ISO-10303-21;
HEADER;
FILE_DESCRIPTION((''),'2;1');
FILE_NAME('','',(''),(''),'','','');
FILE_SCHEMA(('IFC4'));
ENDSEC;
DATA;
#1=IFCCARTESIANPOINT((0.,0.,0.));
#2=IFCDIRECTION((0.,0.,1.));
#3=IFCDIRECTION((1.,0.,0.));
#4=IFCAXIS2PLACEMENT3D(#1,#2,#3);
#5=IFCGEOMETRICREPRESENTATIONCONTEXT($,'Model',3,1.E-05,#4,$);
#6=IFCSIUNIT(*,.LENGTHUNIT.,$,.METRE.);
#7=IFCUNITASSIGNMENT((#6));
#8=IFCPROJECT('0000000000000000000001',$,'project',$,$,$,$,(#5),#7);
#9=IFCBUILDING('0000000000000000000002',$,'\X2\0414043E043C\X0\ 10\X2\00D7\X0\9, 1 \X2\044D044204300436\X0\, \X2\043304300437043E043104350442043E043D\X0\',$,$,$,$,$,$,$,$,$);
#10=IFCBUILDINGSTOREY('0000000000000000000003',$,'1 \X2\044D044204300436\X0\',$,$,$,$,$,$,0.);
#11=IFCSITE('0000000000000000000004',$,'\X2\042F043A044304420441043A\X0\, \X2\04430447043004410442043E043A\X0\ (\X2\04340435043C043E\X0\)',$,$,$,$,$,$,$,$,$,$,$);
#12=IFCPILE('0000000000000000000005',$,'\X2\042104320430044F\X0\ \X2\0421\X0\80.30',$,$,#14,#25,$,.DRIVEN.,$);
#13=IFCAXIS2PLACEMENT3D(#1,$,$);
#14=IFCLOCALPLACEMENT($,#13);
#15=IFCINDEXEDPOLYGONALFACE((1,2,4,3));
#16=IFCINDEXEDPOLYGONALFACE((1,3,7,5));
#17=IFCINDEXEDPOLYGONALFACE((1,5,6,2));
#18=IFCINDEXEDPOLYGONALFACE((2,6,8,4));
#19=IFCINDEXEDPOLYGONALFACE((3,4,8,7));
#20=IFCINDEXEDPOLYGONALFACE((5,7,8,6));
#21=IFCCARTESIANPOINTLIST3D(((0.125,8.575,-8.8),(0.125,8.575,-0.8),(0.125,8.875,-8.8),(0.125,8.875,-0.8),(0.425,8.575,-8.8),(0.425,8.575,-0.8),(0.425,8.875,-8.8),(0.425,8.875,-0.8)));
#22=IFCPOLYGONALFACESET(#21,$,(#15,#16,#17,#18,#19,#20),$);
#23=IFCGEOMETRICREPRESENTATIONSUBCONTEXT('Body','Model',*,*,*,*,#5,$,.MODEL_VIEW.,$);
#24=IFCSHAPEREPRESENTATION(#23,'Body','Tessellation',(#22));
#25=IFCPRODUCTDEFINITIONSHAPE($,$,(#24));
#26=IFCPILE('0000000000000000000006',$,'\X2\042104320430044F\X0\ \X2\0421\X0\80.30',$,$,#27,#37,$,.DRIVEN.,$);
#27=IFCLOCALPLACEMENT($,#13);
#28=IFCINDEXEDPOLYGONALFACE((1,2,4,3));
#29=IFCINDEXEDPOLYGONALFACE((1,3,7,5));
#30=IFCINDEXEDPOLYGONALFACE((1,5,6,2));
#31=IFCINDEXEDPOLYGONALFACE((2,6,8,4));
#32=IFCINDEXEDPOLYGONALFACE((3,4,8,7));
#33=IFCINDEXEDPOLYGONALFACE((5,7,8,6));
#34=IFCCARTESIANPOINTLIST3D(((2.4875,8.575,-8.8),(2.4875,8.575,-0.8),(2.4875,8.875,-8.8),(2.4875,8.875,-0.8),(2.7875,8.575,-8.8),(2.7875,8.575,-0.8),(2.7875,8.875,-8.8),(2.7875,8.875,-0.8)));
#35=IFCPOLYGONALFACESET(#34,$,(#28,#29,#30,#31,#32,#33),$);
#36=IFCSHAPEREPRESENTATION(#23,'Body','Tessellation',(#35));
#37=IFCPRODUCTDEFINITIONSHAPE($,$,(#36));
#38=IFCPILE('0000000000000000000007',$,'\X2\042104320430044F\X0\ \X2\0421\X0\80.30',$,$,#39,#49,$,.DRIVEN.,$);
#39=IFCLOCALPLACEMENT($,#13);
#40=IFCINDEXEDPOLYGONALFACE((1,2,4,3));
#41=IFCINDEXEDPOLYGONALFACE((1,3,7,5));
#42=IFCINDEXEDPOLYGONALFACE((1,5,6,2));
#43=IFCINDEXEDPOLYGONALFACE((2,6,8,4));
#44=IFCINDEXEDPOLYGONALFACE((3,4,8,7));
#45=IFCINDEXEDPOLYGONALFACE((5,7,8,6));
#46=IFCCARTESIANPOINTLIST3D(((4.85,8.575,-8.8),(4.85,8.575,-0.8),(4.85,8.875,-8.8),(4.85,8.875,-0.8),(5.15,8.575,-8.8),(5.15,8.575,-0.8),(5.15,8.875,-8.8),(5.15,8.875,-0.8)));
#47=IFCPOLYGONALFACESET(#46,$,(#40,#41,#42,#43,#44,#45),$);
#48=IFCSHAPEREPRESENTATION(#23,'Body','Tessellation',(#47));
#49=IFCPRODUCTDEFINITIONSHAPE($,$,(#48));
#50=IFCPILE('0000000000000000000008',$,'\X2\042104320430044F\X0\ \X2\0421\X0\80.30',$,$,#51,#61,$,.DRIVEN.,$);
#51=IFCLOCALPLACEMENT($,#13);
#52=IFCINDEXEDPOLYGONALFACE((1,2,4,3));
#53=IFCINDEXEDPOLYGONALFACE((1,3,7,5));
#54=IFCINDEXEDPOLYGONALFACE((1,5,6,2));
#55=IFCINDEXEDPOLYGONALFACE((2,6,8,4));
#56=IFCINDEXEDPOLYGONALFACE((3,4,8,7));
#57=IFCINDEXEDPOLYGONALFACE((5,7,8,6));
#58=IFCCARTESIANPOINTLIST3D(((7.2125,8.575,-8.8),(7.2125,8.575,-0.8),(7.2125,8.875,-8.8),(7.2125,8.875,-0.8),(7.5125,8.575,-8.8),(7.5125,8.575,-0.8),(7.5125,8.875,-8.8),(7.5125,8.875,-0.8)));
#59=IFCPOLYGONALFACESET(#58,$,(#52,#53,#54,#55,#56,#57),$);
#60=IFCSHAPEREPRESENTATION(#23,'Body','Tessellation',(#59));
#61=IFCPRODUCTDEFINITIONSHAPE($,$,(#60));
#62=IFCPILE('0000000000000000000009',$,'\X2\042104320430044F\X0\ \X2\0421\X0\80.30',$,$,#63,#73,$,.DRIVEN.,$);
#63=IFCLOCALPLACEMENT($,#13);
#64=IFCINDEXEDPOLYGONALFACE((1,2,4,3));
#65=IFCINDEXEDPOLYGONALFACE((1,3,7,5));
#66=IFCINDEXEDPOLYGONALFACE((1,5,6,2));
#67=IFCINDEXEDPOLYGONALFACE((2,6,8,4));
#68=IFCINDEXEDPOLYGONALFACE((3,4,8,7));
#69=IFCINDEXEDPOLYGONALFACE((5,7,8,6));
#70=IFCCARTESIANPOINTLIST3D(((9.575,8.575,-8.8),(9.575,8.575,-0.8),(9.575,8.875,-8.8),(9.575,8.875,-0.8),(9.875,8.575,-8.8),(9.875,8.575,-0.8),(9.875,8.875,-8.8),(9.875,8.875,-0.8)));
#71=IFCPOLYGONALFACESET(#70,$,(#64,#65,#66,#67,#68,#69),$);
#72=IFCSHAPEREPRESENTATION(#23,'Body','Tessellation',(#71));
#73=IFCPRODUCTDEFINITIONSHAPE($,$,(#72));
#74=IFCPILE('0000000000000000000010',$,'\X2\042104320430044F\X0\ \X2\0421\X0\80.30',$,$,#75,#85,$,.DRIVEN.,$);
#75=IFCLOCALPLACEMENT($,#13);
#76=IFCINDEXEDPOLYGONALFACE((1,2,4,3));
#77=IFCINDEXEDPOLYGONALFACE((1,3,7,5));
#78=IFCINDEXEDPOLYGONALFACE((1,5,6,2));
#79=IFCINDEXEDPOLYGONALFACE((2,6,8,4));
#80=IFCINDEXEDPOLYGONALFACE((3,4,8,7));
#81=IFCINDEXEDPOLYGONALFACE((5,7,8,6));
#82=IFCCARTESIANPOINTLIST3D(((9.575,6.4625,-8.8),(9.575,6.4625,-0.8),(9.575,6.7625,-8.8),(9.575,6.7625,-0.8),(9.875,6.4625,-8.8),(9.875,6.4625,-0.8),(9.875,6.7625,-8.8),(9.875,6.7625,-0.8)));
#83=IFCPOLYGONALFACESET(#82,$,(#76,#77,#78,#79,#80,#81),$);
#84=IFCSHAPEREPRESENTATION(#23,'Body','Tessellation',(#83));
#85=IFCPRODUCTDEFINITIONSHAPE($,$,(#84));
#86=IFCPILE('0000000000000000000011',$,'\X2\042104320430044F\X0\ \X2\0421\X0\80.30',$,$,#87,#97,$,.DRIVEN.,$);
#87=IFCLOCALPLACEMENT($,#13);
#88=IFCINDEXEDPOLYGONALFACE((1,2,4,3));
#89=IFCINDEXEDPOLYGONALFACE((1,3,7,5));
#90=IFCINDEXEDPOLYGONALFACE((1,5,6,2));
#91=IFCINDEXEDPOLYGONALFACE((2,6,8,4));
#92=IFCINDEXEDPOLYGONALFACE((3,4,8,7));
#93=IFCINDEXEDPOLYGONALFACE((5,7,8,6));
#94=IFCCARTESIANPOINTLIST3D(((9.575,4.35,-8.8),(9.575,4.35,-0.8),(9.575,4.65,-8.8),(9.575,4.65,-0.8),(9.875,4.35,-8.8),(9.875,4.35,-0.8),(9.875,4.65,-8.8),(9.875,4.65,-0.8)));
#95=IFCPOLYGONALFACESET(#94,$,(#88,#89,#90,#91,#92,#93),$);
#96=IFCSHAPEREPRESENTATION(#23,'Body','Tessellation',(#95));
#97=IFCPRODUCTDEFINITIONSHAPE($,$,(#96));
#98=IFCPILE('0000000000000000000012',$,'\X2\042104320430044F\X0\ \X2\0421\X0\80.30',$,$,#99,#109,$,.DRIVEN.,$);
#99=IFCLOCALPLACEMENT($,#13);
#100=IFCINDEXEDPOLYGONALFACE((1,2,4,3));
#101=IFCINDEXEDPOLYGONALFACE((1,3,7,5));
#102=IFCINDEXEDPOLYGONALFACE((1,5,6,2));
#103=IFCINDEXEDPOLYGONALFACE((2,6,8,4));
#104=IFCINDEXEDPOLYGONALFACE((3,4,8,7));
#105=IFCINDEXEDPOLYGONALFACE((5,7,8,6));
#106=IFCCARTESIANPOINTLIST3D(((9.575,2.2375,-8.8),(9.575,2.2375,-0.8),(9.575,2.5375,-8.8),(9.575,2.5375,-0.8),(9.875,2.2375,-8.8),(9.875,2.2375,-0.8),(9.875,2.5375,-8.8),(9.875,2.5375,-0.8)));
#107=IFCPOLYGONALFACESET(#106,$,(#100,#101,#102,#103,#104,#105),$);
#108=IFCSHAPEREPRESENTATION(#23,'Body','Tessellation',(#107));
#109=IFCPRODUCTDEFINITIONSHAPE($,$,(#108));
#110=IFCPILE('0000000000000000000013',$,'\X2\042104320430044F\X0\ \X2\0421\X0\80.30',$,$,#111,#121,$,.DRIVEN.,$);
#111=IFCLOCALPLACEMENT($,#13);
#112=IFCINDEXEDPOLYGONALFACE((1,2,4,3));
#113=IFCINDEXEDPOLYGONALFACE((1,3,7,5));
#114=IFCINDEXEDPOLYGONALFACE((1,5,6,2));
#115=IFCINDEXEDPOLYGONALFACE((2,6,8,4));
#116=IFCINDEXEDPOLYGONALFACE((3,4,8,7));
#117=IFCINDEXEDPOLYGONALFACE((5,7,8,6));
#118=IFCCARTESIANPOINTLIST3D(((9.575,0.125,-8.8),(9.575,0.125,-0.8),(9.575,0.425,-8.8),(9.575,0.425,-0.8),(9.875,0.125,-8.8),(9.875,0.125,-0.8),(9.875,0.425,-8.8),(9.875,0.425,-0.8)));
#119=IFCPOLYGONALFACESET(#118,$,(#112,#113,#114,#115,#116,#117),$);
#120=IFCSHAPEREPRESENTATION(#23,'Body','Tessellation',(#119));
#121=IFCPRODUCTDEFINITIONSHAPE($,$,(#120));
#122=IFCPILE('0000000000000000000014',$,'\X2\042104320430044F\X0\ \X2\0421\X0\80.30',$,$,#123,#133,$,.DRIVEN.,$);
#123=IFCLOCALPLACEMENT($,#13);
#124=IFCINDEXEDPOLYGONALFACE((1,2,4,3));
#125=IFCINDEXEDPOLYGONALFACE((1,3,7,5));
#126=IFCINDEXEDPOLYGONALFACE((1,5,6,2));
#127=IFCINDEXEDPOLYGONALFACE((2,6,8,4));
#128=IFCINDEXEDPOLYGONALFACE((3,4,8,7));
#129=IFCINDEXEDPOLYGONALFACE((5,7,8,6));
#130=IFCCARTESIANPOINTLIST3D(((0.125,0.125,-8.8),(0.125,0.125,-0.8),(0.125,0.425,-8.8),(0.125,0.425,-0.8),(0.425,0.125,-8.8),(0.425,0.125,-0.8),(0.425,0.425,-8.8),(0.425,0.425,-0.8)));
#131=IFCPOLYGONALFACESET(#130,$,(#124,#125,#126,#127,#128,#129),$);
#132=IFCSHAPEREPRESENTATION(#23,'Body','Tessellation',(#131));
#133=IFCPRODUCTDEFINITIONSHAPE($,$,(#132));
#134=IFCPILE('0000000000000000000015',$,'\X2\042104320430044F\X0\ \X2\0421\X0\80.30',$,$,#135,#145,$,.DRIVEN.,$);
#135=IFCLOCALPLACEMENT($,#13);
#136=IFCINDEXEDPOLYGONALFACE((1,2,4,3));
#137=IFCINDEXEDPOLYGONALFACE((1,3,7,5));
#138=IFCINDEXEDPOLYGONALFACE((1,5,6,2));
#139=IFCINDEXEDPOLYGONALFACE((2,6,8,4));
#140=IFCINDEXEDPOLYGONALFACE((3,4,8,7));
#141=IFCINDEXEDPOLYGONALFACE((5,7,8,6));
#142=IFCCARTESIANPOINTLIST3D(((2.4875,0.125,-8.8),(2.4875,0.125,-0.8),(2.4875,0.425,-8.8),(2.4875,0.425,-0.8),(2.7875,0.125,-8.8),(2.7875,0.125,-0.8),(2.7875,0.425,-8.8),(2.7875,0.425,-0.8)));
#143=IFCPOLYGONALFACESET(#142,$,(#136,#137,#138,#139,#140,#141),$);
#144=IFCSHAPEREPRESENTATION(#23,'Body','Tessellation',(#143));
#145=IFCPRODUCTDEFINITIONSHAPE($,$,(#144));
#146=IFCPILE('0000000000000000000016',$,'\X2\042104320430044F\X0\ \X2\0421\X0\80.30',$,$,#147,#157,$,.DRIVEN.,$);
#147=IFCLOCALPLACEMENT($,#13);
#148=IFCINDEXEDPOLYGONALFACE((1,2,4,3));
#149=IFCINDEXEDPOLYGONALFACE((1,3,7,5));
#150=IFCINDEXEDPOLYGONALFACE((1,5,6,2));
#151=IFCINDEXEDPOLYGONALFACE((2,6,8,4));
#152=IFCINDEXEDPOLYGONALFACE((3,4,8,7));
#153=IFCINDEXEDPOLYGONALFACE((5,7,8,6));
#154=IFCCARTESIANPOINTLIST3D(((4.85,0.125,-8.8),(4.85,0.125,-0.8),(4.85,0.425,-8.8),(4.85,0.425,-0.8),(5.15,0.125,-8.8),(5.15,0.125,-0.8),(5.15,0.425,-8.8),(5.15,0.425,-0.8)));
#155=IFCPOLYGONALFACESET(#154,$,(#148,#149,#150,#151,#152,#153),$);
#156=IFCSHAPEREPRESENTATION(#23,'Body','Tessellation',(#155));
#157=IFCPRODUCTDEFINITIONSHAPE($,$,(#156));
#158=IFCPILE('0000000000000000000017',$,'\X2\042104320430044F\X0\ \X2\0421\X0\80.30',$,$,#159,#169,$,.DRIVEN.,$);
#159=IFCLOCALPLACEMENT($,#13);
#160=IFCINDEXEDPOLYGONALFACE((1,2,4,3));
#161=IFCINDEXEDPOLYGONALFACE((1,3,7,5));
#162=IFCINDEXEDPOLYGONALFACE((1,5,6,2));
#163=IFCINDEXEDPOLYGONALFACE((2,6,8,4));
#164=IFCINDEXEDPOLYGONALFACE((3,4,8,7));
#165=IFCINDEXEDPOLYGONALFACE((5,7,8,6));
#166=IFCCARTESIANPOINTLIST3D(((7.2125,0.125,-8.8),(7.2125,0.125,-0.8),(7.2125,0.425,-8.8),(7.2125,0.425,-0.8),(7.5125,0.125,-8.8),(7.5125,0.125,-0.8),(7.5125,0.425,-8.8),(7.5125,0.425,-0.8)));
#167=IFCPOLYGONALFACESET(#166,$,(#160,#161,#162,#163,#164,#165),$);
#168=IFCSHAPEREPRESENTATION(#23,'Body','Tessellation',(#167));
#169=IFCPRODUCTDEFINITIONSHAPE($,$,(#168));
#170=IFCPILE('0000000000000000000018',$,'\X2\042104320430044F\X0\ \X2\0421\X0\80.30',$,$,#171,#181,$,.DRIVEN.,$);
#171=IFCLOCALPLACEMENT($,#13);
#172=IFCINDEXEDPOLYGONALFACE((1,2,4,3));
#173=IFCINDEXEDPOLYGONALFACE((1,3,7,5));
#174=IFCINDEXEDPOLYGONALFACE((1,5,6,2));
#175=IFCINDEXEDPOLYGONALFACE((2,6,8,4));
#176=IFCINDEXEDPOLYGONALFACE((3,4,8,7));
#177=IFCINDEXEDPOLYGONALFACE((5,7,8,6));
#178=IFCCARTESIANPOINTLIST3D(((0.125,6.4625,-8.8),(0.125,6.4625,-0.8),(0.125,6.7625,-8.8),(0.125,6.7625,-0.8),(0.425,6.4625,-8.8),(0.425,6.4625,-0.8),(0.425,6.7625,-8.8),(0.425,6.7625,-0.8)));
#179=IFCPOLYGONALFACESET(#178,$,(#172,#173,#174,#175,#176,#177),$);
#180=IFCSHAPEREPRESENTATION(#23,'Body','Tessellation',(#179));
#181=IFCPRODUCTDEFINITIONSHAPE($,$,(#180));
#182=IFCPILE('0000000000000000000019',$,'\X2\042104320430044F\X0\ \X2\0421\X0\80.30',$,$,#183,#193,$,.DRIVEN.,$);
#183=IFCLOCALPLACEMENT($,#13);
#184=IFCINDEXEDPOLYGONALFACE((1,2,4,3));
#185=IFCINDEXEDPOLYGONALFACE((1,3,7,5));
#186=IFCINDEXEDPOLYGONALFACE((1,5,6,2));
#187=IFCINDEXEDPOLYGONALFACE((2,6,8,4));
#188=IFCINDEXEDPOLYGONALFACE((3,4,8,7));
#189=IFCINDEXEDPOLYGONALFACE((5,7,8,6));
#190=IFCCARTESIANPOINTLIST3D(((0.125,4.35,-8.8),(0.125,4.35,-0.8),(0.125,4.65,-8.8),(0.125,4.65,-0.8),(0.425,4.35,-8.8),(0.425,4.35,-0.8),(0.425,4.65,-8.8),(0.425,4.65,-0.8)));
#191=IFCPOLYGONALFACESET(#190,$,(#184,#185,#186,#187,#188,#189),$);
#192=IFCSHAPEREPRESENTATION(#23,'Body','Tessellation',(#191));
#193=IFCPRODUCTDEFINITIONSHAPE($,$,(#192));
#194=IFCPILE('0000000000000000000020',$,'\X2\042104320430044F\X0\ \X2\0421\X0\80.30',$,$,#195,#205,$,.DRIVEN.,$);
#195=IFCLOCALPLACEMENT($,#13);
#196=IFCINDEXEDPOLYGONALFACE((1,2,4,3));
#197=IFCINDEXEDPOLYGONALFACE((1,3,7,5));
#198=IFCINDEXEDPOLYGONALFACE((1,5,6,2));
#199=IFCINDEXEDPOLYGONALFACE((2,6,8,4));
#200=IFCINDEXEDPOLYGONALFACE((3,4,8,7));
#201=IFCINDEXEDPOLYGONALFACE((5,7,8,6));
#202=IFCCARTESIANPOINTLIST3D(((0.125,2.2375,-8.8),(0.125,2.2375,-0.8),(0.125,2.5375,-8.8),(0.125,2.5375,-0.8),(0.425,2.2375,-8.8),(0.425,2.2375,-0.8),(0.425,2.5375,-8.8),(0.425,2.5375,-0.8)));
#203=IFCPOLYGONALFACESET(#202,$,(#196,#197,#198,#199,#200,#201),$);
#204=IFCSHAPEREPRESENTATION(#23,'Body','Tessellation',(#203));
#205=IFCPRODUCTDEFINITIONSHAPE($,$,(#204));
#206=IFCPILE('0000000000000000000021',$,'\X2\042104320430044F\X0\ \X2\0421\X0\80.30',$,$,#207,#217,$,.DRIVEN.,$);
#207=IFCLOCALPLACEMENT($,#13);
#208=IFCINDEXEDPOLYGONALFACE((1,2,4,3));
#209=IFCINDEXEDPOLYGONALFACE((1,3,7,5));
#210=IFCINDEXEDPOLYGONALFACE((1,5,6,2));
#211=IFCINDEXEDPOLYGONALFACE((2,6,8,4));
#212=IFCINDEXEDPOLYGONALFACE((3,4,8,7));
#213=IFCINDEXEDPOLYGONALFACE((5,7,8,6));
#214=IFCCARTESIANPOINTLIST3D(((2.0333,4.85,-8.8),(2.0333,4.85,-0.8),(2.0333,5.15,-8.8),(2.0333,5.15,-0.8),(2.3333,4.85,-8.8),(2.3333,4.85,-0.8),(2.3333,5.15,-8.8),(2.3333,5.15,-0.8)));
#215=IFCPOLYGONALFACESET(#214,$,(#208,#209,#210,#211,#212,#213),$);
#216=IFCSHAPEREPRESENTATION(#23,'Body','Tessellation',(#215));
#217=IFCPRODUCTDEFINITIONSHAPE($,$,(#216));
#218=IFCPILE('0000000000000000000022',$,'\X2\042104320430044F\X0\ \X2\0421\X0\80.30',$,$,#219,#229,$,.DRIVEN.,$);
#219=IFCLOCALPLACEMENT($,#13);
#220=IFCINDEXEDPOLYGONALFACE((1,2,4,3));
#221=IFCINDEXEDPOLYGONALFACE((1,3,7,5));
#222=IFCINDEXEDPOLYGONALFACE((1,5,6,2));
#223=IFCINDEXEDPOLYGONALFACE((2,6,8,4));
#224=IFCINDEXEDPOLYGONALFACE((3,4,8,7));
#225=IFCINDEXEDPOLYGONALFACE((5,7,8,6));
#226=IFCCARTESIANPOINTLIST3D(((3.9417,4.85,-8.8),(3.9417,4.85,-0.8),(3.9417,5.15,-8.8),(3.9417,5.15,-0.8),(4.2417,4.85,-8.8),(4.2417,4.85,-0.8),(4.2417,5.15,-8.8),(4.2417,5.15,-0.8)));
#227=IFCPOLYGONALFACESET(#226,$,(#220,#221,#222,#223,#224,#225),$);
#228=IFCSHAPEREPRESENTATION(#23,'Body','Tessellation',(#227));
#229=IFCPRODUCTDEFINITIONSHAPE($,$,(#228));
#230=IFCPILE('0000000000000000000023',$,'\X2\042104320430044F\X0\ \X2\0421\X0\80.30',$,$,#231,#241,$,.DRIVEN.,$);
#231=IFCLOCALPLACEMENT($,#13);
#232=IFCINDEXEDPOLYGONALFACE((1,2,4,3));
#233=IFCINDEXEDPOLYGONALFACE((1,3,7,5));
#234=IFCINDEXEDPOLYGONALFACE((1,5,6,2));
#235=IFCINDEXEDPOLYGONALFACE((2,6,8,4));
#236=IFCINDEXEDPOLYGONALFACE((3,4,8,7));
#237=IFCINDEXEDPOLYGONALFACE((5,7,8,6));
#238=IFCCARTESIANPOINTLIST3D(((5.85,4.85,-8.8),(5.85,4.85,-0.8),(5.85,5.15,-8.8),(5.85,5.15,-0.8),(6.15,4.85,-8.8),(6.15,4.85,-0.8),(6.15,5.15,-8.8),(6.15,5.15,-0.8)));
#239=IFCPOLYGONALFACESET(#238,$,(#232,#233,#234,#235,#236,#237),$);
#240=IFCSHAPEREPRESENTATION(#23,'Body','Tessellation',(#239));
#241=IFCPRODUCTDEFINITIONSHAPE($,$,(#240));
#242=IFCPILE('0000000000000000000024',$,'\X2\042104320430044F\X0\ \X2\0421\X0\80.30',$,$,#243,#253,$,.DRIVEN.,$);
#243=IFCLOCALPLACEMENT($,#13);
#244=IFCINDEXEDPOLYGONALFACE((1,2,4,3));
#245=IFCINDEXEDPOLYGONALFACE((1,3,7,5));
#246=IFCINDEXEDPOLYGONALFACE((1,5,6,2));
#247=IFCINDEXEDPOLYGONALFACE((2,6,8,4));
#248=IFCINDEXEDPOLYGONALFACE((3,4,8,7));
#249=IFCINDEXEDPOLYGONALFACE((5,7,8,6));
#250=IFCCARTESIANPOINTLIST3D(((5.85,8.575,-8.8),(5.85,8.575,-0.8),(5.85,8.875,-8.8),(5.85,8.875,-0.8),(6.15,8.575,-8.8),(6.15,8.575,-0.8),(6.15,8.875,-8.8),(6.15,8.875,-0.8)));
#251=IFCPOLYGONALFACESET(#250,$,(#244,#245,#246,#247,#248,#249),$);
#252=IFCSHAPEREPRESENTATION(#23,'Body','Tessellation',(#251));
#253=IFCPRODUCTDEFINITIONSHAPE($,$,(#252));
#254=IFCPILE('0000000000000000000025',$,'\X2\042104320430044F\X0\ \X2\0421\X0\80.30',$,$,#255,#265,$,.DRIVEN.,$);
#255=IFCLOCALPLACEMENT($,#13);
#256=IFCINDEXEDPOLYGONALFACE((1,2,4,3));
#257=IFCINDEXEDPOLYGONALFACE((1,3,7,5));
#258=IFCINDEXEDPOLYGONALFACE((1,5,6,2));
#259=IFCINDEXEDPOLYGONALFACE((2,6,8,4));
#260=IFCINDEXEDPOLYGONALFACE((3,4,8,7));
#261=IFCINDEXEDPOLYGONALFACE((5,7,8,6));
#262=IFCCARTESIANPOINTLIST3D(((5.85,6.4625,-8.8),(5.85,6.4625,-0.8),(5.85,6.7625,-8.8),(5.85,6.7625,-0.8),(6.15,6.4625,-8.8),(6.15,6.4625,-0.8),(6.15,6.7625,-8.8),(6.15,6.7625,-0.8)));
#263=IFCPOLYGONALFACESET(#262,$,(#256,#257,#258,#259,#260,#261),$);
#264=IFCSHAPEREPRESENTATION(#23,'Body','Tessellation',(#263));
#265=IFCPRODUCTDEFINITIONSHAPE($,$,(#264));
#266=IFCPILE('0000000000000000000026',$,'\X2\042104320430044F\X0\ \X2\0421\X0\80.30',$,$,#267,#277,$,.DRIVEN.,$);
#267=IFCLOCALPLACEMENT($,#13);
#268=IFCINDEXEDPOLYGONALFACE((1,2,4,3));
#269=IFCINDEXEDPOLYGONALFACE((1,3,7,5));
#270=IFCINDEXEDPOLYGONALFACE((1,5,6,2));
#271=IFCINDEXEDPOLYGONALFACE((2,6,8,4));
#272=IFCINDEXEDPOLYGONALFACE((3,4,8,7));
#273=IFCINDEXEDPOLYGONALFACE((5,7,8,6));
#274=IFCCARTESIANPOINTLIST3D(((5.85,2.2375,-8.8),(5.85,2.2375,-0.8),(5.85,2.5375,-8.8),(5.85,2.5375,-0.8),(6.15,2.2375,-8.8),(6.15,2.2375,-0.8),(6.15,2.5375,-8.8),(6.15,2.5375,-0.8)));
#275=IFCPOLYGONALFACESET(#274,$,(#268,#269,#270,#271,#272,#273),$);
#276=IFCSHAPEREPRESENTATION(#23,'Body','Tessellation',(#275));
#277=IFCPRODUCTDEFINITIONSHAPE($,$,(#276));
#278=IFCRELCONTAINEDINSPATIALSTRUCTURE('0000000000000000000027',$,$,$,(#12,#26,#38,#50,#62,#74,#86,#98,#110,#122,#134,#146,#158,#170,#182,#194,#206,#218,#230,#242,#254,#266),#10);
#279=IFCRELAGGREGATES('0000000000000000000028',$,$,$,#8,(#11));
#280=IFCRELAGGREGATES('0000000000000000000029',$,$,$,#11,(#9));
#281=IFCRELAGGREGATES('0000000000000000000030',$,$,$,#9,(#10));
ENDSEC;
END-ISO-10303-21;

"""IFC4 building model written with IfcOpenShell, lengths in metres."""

from ifc_helpers import new_model, si_unit, frame, origin_with_axes, place, context, subcontext, project, spatial, rectangle, extrude, element, save


model = new_model("IFC4")

# Units and contexts
model_context = context("Model", 3, precision=1e-05, world=origin_with_axes())
body_context = subcontext(model_context, "Body", "Model", "MODEL_VIEW")
ifc_project = project(units=[si_unit("LENGTHUNIT", "METRE")], contexts=[model_context])

# Site, building, storey
site = spatial("IfcSite", under=ifc_project, Name="Якутск, участок (демо)")
building = spatial("IfcBuilding", under=site, Name="Дом 10×9, 1 этаж, газобетон")
storey = spatial("IfcBuildingStorey", under=building, Name="1 этаж", Elevation=0.0)

# Piles
for number, where, z_axis, x_axis, name in (
    (1, (0.275, 8.725, -8.8), (0.0, 0.0, 1.0), (1.0, 0.0, 0.0), "Свая С80.30"),
    (2, (2.6375, 8.725, -8.8), (0.0, 0.0, 1.0), (1.0, 0.0, 0.0), "Свая С80.30"),
    (3, (5.0, 8.725, -8.8), (0.0, 0.0, 1.0), (1.0, 0.0, 0.0), "Свая С80.30"),
    (4, (7.3625, 8.725, -8.8), (0.0, 0.0, 1.0), (1.0, 0.0, 0.0), "Свая С80.30"),
    (5, (9.725, 8.725, -8.8), (0.0, 0.0, 1.0), (1.0, 0.0, 0.0), "Свая С80.30"),
    (6, (9.725, 6.6125, -8.8), (0.0, 0.0, 1.0), (1.0, 0.0, 0.0), "Свая С80.30"),
    (7, (9.725, 4.5, -8.8), (0.0, 0.0, 1.0), (1.0, 0.0, 0.0), "Свая С80.30"),
    (8, (9.725, 2.3875, -8.8), (0.0, 0.0, 1.0), (1.0, 0.0, 0.0), "Свая С80.30"),
    (9, (9.725, 0.275, -8.8), (0.0, 0.0, 1.0), (1.0, 0.0, 0.0), "Свая С80.30"),
    (10, (0.275, 0.275, -8.8), (0.0, 0.0, 1.0), (1.0, 0.0, 0.0), "Свая С80.30"),
    (11, (2.6375, 0.275, -8.8), (0.0, 0.0, 1.0), (1.0, 0.0, 0.0), "Свая С80.30"),
    (12, (5.0, 0.275, -8.8), (0.0, 0.0, 1.0), (1.0, 0.0, 0.0), "Свая С80.30"),
    (13, (7.3625, 0.275, -8.8), (0.0, 0.0, 1.0), (1.0, 0.0, 0.0), "Свая С80.30"),
    (14, (0.275, 6.6125, -8.8), (0.0, 0.0, 1.0), (1.0, 0.0, 0.0), "Свая С80.30"),
    (15, (0.275, 4.5, -8.8), (0.0, 0.0, 1.0), (1.0, 0.0, 0.0), "Свая С80.30"),
    (16, (0.275, 2.3875, -8.8), (0.0, 0.0, 1.0), (1.0, 0.0, 0.0), "Свая С80.30"),
    (17, (2.1833, 5.0, -8.8), (0.0, 0.0, 1.0), (1.0, 0.0, 0.0), "Свая С80.30"),
    (18, (4.0917, 5.0, -8.8), (0.0, 0.0, 1.0), (1.0, 0.0, 0.0), "Свая С80.30"),
    (19, (6.0, 5.0, -8.8), (0.0, 0.0, 1.0), (1.0, 0.0, 0.0), "Свая С80.30"),
    (20, (6.0, 8.725, -8.8), (0.0, 0.0, 1.0), (1.0, 0.0, 0.0), "Свая С80.30"),
    (21, (6.0, 6.6125, -8.8), (0.0, 0.0, 1.0), (1.0, 0.0, 0.0), "Свая С80.30"),
    (22, (6.0, 2.3875, -8.8), (0.0, 0.0, 1.0), (1.0, 0.0, 0.0), "Свая С80.30"),
):
    element("IfcPile", number, at=place(None, frame(where, z_axis=z_axis, x_axis=x_axis)), inside=storey, Name=name, PredefinedType="DRIVEN", context=body_context, shape_type="SweptSolid", body=[
        extrude(rectangle(XDim=0.3, YDim=0.3), origin_with_axes(), (0.0, 0.0, 1.0), 8.0),
    ])

save(model, "model.ifc")
